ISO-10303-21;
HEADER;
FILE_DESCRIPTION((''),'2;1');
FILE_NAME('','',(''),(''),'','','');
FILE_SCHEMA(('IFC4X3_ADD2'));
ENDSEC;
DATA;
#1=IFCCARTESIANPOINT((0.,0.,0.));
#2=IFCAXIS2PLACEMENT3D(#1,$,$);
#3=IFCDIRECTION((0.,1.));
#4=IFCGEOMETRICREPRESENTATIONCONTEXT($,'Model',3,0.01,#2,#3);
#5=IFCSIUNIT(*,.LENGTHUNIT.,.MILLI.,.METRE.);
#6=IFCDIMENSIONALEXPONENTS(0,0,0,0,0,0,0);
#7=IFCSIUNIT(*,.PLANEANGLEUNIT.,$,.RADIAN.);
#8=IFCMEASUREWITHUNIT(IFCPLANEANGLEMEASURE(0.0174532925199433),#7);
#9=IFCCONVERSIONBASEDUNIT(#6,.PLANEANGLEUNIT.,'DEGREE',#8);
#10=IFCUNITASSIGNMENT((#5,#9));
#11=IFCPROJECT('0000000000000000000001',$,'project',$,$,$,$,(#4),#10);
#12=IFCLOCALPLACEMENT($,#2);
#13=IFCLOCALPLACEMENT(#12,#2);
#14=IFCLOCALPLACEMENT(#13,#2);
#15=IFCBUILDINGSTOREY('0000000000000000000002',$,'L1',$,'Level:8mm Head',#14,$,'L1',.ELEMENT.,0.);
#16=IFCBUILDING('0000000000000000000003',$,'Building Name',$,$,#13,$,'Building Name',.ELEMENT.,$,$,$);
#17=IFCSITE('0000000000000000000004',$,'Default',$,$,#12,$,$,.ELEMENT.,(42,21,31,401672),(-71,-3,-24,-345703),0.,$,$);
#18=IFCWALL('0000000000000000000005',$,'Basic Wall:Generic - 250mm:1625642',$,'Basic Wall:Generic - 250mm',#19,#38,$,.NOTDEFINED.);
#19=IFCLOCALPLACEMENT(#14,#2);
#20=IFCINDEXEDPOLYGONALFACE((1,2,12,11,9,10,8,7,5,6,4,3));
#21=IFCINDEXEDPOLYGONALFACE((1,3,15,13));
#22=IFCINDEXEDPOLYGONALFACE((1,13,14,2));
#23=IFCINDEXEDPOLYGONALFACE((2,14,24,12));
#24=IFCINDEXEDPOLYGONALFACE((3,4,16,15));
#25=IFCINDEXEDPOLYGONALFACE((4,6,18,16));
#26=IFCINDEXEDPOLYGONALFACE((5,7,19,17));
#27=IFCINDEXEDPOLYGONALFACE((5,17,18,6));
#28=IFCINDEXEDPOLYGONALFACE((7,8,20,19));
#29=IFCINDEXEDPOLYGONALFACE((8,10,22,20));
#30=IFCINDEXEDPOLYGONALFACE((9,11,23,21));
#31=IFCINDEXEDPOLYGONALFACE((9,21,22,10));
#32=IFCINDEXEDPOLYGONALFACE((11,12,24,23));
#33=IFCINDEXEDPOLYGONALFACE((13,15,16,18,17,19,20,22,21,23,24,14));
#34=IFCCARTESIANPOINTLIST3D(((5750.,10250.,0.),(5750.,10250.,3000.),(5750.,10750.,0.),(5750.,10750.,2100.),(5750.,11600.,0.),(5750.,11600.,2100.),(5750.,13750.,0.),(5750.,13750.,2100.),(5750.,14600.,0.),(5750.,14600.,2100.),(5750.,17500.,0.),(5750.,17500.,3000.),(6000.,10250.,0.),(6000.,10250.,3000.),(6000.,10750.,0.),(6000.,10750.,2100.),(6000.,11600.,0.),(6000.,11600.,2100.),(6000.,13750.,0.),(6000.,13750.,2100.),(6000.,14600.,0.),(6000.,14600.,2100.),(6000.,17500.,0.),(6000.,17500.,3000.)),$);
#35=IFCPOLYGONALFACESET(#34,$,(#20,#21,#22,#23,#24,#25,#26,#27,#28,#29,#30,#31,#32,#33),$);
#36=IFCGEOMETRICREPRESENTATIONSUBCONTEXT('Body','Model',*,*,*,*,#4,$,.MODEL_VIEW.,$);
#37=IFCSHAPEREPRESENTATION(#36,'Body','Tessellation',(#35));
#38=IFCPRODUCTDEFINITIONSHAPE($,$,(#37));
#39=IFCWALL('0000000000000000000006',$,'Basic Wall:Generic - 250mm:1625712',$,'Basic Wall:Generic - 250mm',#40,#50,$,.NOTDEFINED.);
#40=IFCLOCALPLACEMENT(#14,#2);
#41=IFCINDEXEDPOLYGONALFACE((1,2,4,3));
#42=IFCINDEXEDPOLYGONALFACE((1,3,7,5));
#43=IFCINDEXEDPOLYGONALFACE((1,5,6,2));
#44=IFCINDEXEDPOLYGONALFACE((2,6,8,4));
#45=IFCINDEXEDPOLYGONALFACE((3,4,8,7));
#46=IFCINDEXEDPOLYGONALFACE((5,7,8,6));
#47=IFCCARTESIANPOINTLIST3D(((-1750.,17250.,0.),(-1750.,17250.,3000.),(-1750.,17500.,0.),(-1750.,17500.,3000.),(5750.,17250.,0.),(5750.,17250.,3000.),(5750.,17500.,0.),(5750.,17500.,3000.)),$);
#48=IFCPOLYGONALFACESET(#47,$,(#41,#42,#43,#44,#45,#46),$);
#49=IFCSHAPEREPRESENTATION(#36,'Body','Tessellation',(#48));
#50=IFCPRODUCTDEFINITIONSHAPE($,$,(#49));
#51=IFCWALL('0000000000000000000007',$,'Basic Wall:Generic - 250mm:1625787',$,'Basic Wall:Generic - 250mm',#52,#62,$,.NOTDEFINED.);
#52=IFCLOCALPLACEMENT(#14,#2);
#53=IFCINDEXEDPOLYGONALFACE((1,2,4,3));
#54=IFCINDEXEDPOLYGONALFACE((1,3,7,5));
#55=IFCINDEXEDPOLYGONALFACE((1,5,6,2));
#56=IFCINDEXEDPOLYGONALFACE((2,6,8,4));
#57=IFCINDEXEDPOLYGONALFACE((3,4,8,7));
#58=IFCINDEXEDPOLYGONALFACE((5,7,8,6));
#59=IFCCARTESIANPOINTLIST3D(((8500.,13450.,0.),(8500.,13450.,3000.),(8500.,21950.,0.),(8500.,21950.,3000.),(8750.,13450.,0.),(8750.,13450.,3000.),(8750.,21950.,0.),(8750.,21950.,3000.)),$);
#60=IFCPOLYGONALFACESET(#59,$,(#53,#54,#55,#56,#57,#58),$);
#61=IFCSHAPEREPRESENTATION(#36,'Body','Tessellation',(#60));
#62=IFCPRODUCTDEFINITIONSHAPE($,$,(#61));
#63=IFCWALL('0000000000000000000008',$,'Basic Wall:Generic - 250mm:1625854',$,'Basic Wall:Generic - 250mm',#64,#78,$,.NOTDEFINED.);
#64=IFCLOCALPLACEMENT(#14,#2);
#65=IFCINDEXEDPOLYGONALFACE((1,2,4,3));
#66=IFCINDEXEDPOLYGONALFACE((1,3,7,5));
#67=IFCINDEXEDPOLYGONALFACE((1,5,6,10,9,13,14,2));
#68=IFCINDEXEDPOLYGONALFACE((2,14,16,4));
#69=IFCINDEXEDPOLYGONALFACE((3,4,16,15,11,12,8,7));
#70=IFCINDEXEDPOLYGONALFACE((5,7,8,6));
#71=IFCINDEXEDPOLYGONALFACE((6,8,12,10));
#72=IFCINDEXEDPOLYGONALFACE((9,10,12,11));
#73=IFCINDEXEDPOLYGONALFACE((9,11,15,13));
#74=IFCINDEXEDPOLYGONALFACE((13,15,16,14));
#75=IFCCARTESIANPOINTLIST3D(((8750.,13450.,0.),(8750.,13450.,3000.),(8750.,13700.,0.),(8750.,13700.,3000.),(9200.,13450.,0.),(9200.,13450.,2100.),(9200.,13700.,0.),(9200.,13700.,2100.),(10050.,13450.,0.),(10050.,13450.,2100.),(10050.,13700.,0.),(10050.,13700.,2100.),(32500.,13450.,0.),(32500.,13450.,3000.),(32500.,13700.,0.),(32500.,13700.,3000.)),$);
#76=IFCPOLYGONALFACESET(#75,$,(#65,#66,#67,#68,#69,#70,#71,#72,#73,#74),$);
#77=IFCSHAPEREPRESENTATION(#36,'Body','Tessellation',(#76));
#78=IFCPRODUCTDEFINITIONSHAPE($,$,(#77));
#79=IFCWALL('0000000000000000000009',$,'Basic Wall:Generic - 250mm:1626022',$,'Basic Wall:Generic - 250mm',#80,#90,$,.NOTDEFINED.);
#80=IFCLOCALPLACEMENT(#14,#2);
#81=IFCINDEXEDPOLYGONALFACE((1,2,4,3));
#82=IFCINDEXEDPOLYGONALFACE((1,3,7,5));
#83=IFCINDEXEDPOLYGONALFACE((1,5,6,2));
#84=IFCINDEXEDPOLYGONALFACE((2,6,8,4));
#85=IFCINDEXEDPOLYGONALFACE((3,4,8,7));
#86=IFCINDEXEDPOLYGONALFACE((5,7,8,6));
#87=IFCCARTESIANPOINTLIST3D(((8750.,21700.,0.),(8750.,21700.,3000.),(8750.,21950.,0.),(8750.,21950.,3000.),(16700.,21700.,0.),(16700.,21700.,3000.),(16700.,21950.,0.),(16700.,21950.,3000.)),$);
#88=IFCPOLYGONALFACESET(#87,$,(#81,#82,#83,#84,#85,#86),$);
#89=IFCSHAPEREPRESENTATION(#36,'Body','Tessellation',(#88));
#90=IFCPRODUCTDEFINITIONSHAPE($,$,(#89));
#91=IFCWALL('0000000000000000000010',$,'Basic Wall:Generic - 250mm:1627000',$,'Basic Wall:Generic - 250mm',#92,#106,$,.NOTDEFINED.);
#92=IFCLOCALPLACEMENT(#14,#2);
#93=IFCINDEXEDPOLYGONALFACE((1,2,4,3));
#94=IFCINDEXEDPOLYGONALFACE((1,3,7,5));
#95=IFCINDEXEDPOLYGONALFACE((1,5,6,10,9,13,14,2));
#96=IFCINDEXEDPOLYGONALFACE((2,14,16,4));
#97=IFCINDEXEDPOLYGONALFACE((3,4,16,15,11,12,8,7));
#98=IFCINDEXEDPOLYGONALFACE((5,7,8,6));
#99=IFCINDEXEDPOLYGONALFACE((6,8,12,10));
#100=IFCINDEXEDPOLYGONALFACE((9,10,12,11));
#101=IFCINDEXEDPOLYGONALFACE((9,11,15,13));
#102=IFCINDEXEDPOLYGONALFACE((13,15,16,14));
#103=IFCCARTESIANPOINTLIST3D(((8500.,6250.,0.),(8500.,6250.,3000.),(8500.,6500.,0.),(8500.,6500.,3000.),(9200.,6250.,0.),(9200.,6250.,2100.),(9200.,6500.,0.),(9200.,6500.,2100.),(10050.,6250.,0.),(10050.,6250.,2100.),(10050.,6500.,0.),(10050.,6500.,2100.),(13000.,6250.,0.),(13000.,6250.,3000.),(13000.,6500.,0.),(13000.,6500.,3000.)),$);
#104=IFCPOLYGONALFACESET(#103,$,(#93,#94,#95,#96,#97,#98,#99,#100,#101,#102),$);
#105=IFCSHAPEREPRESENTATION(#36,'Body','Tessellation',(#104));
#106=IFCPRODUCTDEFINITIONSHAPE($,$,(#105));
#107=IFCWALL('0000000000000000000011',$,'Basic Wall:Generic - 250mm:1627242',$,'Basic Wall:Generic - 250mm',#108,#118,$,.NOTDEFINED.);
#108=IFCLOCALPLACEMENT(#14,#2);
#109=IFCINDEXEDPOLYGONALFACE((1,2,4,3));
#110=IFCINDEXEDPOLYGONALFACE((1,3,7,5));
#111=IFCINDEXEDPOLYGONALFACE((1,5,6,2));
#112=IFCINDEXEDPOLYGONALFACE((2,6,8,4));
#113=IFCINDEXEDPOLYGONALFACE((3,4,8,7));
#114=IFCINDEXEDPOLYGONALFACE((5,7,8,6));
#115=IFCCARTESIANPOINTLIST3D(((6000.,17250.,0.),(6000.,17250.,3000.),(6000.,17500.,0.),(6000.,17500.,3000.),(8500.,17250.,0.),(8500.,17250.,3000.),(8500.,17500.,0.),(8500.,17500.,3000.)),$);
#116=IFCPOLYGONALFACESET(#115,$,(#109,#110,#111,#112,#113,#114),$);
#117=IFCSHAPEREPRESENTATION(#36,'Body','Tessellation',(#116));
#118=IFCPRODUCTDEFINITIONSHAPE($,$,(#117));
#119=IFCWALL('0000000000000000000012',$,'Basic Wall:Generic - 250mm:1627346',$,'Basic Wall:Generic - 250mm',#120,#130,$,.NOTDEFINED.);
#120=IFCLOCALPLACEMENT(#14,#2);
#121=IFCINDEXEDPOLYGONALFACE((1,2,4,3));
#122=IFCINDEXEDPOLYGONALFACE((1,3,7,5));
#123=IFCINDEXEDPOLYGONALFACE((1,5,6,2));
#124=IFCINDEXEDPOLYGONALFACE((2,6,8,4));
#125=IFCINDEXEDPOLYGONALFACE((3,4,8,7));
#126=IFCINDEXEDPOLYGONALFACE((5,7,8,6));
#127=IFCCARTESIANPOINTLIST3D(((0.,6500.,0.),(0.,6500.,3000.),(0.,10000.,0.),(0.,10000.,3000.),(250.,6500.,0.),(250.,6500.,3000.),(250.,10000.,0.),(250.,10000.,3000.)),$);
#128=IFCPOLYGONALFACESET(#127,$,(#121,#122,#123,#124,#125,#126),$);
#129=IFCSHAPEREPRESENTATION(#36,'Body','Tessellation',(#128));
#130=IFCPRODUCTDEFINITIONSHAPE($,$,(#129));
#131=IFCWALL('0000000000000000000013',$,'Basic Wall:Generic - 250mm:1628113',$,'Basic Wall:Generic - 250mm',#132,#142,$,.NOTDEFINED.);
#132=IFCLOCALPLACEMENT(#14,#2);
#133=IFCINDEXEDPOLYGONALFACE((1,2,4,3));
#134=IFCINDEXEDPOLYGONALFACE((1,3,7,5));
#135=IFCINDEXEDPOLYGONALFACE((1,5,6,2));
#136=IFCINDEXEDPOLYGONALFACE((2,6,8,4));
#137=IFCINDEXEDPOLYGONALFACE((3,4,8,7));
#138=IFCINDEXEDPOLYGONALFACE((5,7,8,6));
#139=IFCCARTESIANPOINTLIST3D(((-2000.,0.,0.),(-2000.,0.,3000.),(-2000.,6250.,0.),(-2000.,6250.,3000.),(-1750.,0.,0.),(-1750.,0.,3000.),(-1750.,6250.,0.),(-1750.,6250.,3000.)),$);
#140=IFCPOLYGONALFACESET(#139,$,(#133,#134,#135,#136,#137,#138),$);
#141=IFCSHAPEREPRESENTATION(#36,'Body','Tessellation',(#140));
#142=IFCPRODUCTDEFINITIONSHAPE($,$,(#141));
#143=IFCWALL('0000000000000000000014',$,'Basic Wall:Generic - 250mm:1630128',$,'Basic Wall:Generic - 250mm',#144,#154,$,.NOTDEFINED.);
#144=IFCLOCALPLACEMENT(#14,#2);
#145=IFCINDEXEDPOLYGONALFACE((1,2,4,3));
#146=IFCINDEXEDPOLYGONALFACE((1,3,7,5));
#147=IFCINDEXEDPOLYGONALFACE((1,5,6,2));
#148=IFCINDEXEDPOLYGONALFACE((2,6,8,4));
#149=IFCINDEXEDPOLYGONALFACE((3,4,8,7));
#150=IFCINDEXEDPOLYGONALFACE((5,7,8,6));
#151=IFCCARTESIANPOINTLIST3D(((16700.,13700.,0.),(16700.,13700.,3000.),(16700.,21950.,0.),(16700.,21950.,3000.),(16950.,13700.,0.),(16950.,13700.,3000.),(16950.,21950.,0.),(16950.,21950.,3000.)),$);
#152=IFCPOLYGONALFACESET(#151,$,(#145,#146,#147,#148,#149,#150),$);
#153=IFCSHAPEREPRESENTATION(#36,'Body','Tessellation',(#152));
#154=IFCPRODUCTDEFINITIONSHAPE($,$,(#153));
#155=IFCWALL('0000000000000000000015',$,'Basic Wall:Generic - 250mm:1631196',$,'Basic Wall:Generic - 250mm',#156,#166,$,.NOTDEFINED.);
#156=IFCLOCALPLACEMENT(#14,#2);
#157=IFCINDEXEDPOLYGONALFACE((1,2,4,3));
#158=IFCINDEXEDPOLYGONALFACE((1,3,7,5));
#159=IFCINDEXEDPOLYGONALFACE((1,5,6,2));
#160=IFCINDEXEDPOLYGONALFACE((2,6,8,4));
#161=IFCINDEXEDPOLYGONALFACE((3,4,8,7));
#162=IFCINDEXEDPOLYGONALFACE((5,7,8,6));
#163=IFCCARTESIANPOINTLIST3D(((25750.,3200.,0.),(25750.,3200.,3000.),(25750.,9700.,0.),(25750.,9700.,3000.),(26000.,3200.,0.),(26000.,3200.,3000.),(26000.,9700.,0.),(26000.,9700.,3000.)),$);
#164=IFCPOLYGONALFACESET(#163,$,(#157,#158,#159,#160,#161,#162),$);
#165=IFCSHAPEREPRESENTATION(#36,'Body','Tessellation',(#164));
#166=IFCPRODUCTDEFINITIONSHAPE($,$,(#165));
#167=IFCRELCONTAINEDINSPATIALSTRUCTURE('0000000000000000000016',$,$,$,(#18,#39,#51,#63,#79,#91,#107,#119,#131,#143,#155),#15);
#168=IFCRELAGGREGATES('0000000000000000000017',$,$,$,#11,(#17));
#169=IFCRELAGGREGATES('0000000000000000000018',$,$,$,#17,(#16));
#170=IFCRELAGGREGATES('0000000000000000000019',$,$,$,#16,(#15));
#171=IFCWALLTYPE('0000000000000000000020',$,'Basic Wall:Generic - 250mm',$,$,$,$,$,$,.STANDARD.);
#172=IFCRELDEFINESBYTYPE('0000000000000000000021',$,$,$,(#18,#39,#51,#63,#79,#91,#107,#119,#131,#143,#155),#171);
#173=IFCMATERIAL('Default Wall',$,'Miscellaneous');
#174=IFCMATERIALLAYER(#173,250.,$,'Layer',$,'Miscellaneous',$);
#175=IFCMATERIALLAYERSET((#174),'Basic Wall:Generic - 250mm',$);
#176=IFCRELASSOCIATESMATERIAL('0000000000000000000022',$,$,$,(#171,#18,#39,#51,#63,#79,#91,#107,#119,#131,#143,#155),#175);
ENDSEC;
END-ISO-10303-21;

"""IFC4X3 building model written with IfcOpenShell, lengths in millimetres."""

from ifc_helpers import new_model, entity, si_unit, converted_unit, direction, frame, frame_2d, origin, place, context, subcontext, project, spatial, rectangle, extrude, material, layer, layer_set, type_object, element, save


model = new_model("IFC4X3")

# Units and contexts
model_context = context("Model", 3, precision=0.01, world=origin(), true_north=direction((0.0, 1.0)))
body_context = subcontext(model_context, "Body", "Model", "MODEL_VIEW")
ifc_project = project(units=[si_unit("LENGTHUNIT", "METRE", prefix="MILLI"), converted_unit("PLANEANGLEUNIT", "DEGREE", entity("IfcPlaneAngleMeasure", 0.0174532925199433), si_unit("PLANEANGLEUNIT", "RADIAN"), dimensions=[0, 0, 0, 0, 0, 0, 0])], contexts=[model_context])

# Site, building, storey
site_placement = place(None, origin())
site = spatial("IfcSite", under=ifc_project, at=site_placement, Name="Default", CompositionType="ELEMENT", RefLatitude=(42, 21, 31, 401672), RefLongitude=(-71, -3, -24, -345703), RefElevation=0.0)
building_placement = place(site_placement, origin())
building = spatial("IfcBuilding", under=site, at=building_placement, Name="Building Name", LongName="Building Name", CompositionType="ELEMENT")
storey_placement = place(building_placement, origin())
storey = spatial("IfcBuildingStorey", under=building, at=storey_placement, Name="L1", ObjectType="Level:8mm Head", LongName="L1", CompositionType="ELEMENT", Elevation=0.0)

# Shared definitions
ifc_material = material(Name="Default Wall", Category="Miscellaneous")
ifc_layer = layer(ifc_material, 250.0, Name="Layer", Category="Miscellaneous")
ifc_layer_set = layer_set([ifc_layer], Name="Basic Wall:Generic - 250mm")
wall_type = type_object("IfcWallType", Name="Basic Wall:Generic - 250mm", PredefinedType="STANDARD", material=ifc_layer_set)

# Wall, openings
wall_1_placement = place(storey_placement, frame((5875.0, 10250.0, 0.0), z_axis=(0.0, 0.0, 1.0), x_axis=(0.0, 1.0, 0.0)))
wall_1 = element("IfcWall", 1, at=wall_1_placement, inside=storey, type_object=wall_type, material=ifc_layer_set, Name="Basic Wall:Generic - 250mm:1625642", ObjectType="Basic Wall:Generic - 250mm", PredefinedType="NOTDEFINED", context=body_context, shape_type="SweptSolid", body=[
    extrude(rectangle(XDim=7250.0, YDim=250.0, at=frame_2d((3625.0, 0.0), x_axis=(1.0, 0.0))), origin(), (0.0, 0.0, 1.0), 3000.0),
])
opening_1_placement = place(wall_1_placement, frame((500.0, -125.0, 0.0)))
element("IfcOpeningElement", 2, at=opening_1_placement, cuts=wall_1, PredefinedType="OPENING", context=body_context, shape_type="SweptSolid", body=[
    extrude(rectangle(XDim=2100.0, YDim=850.0, at=frame_2d((1050.0, 425.0), x_axis=(1.0, 0.0))), frame((0.0, 0.0, 0.0), z_axis=(0.0, 1.0, 0.0), x_axis=(0.0, 0.0, 1.0)), (0.0, 0.0, 1.0), 250.0),
])
opening_2_placement = place(wall_1_placement, frame((4350.0, 125.0, 0.0)))
element("IfcOpeningElement", 3, at=opening_2_placement, cuts=wall_1, PredefinedType="OPENING", context=body_context, shape_type="SweptSolid", body=[
    extrude(rectangle(XDim=2100.0, YDim=850.0, at=frame_2d((1050.0, 425.0), x_axis=(1.0, 0.0))), frame((0.0, 0.0, 0.0), z_axis=(0.0, -1.0, 0.0), x_axis=(0.0, 0.0, 1.0)), (0.0, 0.0, 1.0), 250.0),
])

# Walls
wall_2_placement = place(storey_placement, frame((5750.0, 17375.0, 0.0), z_axis=(0.0, 0.0, 1.0), x_axis=(-1.0, 0.0, 0.0)))
element("IfcWall", 4, at=wall_2_placement, inside=storey, type_object=wall_type, material=ifc_layer_set, Name="Basic Wall:Generic - 250mm:1625712", ObjectType="Basic Wall:Generic - 250mm", PredefinedType="NOTDEFINED", context=body_context, shape_type="SweptSolid", body=[
    extrude(rectangle(XDim=7500.0, YDim=250.0, at=frame_2d((3750.0, 0.0), x_axis=(-1.0, 0.0))), origin(), (0.0, 0.0, 1.0), 3000.0),
])
wall_3_placement = place(storey_placement, frame((8625.0, 21950.0, 0.0), z_axis=(0.0, 0.0, 1.0), x_axis=(0.0, -1.0, 0.0)))
element("IfcWall", 5, at=wall_3_placement, inside=storey, type_object=wall_type, material=ifc_layer_set, Name="Basic Wall:Generic - 250mm:1625787", ObjectType="Basic Wall:Generic - 250mm", PredefinedType="NOTDEFINED", context=body_context, shape_type="SweptSolid", body=[
    extrude(rectangle(XDim=8500.0, YDim=250.0, at=frame_2d((4250.0, 0.0), x_axis=(-1.0, 0.0))), origin(), (0.0, 0.0, 1.0), 3000.0),
])

# Wall, opening
wall_4_placement = place(storey_placement, frame((8750.0, 13575.0, 0.0)))
wall_4 = element("IfcWall", 6, at=wall_4_placement, inside=storey, type_object=wall_type, material=ifc_layer_set, Name="Basic Wall:Generic - 250mm:1625854", ObjectType="Basic Wall:Generic - 250mm", PredefinedType="NOTDEFINED", context=body_context, shape_type="SweptSolid", body=[
    extrude(rectangle(XDim=23750.0, YDim=250.0, at=frame_2d((11875.0, 0.0), x_axis=(-1.0, 0.0))), origin(), (0.0, 0.0, 1.0), 3000.0),
])
opening_3_placement = place(wall_4_placement, frame((450.0, -125.0, 0.0)))
element("IfcOpeningElement", 7, at=opening_3_placement, cuts=wall_4, PredefinedType="OPENING", context=body_context, shape_type="SweptSolid", body=[
    extrude(rectangle(XDim=2100.0, YDim=850.0, at=frame_2d((1050.0, 425.0), x_axis=(1.0, 0.0))), frame((0.0, 0.0, 0.0), z_axis=(0.0, 1.0, 0.0), x_axis=(0.0, 0.0, 1.0)), (0.0, 0.0, 1.0), 250.0),
])

# Wall
wall_5_placement = place(storey_placement, frame((16700.0, 21825.0, 0.0), z_axis=(0.0, 0.0, 1.0), x_axis=(-1.0, 0.0, 0.0)))
element("IfcWall", 8, at=wall_5_placement, inside=storey, type_object=wall_type, material=ifc_layer_set, Name="Basic Wall:Generic - 250mm:1626022", ObjectType="Basic Wall:Generic - 250mm", PredefinedType="NOTDEFINED", context=body_context, shape_type="SweptSolid", body=[
    extrude(rectangle(XDim=7950.0, YDim=250.0, at=frame_2d((3975.0, 0.0), x_axis=(-1.0, 0.0))), origin(), (0.0, 0.0, 1.0), 3000.0),
])

# Wall, opening
wall_6_placement = place(storey_placement, frame((13000.0, 6375.0, 0.0), z_axis=(0.0, 0.0, 1.0), x_axis=(-1.0, 0.0, 0.0)))
wall_6 = element("IfcWall", 9, at=wall_6_placement, inside=storey, type_object=wall_type, material=ifc_layer_set, Name="Basic Wall:Generic - 250mm:1627000", ObjectType="Basic Wall:Generic - 250mm", PredefinedType="NOTDEFINED", context=body_context, shape_type="SweptSolid", body=[
    extrude(rectangle(XDim=4500.0, YDim=250.0, at=frame_2d((2250.0, 0.0), x_axis=(-1.0, 0.0))), origin(), (0.0, 0.0, 1.0), 3000.0),
])
opening_4_placement = place(wall_6_placement, frame((3800.0, 125.0, 0.0)))
element("IfcOpeningElement", 10, at=opening_4_placement, cuts=wall_6, PredefinedType="OPENING", context=body_context, shape_type="SweptSolid", body=[
    extrude(rectangle(XDim=2100.0, YDim=850.0, at=frame_2d((1050.0, 425.0), x_axis=(1.0, 0.0))), frame((0.0, 0.0, 0.0), z_axis=(0.0, -1.0, 0.0), x_axis=(0.0, 0.0, 1.0)), (0.0, 0.0, 1.0), 250.0),
])

# Walls
wall_7_placement = place(storey_placement, frame((6000.0, 17375.0, 0.0)))
element("IfcWall", 11, at=wall_7_placement, inside=storey, type_object=wall_type, material=ifc_layer_set, Name="Basic Wall:Generic - 250mm:1627242", ObjectType="Basic Wall:Generic - 250mm", PredefinedType="NOTDEFINED", context=body_context, shape_type="SweptSolid", body=[
    extrude(rectangle(XDim=2500.0, YDim=250.0, at=frame_2d((1250.0, 0.0), x_axis=(-1.0, 0.0))), origin(), (0.0, 0.0, 1.0), 3000.0),
])
wall_8_placement = place(storey_placement, frame((125.0, 6500.0, 0.0), z_axis=(0.0, 0.0, 1.0), x_axis=(0.0, 1.0, 0.0)))
element("IfcWall", 12, at=wall_8_placement, inside=storey, type_object=wall_type, material=ifc_layer_set, Name="Basic Wall:Generic - 250mm:1627346", ObjectType="Basic Wall:Generic - 250mm", PredefinedType="NOTDEFINED", context=body_context, shape_type="SweptSolid", body=[
    extrude(rectangle(XDim=3500.0, YDim=250.0, at=frame_2d((1750.0, 0.0), x_axis=(-1.0, 0.0))), origin(), (0.0, 0.0, 1.0), 3000.0),
])
wall_9_placement = place(storey_placement, frame((-1875.0, 6250.0, 0.0), z_axis=(0.0, 0.0, 1.0), x_axis=(0.0, -1.0, 0.0)))
element("IfcWall", 13, at=wall_9_placement, inside=storey, type_object=wall_type, material=ifc_layer_set, Name="Basic Wall:Generic - 250mm:1628113", ObjectType="Basic Wall:Generic - 250mm", PredefinedType="NOTDEFINED", context=body_context, shape_type="SweptSolid", body=[
    extrude(rectangle(XDim=6250.0, YDim=250.0, at=frame_2d((3125.0, 0.0), x_axis=(-1.0, 0.0))), origin(), (0.0, 0.0, 1.0), 3000.0),
])
wall_10_placement = place(storey_placement, frame((16825.0, 13700.0, 0.0), z_axis=(0.0, 0.0, 1.0), x_axis=(0.0, 1.0, 0.0)))
element("IfcWall", 14, at=wall_10_placement, inside=storey, type_object=wall_type, material=ifc_layer_set, Name="Basic Wall:Generic - 250mm:1630128", ObjectType="Basic Wall:Generic - 250mm", PredefinedType="NOTDEFINED", context=body_context, shape_type="SweptSolid", body=[
    extrude(rectangle(XDim=8250.0, YDim=250.0, at=frame_2d((4125.0, 0.0), x_axis=(-1.0, 0.0))), origin(), (0.0, 0.0, 1.0), 3000.0),
])
wall_11_placement = place(storey_placement, frame((25875.0, 3200.0, 0.0), z_axis=(0.0, 0.0, 1.0), x_axis=(0.0, 1.0, 0.0)))
element("IfcWall", 15, at=wall_11_placement, inside=storey, type_object=wall_type, material=ifc_layer_set, Name="Basic Wall:Generic - 250mm:1631196", ObjectType="Basic Wall:Generic - 250mm", PredefinedType="NOTDEFINED", context=body_context, shape_type="SweptSolid", body=[
    extrude(rectangle(XDim=6500.0, YDim=250.0, at=frame_2d((3250.0, 0.0), x_axis=(-1.0, 0.0))), origin(), (0.0, 0.0, 1.0), 3000.0),
])

save(model, "model.ifc")
